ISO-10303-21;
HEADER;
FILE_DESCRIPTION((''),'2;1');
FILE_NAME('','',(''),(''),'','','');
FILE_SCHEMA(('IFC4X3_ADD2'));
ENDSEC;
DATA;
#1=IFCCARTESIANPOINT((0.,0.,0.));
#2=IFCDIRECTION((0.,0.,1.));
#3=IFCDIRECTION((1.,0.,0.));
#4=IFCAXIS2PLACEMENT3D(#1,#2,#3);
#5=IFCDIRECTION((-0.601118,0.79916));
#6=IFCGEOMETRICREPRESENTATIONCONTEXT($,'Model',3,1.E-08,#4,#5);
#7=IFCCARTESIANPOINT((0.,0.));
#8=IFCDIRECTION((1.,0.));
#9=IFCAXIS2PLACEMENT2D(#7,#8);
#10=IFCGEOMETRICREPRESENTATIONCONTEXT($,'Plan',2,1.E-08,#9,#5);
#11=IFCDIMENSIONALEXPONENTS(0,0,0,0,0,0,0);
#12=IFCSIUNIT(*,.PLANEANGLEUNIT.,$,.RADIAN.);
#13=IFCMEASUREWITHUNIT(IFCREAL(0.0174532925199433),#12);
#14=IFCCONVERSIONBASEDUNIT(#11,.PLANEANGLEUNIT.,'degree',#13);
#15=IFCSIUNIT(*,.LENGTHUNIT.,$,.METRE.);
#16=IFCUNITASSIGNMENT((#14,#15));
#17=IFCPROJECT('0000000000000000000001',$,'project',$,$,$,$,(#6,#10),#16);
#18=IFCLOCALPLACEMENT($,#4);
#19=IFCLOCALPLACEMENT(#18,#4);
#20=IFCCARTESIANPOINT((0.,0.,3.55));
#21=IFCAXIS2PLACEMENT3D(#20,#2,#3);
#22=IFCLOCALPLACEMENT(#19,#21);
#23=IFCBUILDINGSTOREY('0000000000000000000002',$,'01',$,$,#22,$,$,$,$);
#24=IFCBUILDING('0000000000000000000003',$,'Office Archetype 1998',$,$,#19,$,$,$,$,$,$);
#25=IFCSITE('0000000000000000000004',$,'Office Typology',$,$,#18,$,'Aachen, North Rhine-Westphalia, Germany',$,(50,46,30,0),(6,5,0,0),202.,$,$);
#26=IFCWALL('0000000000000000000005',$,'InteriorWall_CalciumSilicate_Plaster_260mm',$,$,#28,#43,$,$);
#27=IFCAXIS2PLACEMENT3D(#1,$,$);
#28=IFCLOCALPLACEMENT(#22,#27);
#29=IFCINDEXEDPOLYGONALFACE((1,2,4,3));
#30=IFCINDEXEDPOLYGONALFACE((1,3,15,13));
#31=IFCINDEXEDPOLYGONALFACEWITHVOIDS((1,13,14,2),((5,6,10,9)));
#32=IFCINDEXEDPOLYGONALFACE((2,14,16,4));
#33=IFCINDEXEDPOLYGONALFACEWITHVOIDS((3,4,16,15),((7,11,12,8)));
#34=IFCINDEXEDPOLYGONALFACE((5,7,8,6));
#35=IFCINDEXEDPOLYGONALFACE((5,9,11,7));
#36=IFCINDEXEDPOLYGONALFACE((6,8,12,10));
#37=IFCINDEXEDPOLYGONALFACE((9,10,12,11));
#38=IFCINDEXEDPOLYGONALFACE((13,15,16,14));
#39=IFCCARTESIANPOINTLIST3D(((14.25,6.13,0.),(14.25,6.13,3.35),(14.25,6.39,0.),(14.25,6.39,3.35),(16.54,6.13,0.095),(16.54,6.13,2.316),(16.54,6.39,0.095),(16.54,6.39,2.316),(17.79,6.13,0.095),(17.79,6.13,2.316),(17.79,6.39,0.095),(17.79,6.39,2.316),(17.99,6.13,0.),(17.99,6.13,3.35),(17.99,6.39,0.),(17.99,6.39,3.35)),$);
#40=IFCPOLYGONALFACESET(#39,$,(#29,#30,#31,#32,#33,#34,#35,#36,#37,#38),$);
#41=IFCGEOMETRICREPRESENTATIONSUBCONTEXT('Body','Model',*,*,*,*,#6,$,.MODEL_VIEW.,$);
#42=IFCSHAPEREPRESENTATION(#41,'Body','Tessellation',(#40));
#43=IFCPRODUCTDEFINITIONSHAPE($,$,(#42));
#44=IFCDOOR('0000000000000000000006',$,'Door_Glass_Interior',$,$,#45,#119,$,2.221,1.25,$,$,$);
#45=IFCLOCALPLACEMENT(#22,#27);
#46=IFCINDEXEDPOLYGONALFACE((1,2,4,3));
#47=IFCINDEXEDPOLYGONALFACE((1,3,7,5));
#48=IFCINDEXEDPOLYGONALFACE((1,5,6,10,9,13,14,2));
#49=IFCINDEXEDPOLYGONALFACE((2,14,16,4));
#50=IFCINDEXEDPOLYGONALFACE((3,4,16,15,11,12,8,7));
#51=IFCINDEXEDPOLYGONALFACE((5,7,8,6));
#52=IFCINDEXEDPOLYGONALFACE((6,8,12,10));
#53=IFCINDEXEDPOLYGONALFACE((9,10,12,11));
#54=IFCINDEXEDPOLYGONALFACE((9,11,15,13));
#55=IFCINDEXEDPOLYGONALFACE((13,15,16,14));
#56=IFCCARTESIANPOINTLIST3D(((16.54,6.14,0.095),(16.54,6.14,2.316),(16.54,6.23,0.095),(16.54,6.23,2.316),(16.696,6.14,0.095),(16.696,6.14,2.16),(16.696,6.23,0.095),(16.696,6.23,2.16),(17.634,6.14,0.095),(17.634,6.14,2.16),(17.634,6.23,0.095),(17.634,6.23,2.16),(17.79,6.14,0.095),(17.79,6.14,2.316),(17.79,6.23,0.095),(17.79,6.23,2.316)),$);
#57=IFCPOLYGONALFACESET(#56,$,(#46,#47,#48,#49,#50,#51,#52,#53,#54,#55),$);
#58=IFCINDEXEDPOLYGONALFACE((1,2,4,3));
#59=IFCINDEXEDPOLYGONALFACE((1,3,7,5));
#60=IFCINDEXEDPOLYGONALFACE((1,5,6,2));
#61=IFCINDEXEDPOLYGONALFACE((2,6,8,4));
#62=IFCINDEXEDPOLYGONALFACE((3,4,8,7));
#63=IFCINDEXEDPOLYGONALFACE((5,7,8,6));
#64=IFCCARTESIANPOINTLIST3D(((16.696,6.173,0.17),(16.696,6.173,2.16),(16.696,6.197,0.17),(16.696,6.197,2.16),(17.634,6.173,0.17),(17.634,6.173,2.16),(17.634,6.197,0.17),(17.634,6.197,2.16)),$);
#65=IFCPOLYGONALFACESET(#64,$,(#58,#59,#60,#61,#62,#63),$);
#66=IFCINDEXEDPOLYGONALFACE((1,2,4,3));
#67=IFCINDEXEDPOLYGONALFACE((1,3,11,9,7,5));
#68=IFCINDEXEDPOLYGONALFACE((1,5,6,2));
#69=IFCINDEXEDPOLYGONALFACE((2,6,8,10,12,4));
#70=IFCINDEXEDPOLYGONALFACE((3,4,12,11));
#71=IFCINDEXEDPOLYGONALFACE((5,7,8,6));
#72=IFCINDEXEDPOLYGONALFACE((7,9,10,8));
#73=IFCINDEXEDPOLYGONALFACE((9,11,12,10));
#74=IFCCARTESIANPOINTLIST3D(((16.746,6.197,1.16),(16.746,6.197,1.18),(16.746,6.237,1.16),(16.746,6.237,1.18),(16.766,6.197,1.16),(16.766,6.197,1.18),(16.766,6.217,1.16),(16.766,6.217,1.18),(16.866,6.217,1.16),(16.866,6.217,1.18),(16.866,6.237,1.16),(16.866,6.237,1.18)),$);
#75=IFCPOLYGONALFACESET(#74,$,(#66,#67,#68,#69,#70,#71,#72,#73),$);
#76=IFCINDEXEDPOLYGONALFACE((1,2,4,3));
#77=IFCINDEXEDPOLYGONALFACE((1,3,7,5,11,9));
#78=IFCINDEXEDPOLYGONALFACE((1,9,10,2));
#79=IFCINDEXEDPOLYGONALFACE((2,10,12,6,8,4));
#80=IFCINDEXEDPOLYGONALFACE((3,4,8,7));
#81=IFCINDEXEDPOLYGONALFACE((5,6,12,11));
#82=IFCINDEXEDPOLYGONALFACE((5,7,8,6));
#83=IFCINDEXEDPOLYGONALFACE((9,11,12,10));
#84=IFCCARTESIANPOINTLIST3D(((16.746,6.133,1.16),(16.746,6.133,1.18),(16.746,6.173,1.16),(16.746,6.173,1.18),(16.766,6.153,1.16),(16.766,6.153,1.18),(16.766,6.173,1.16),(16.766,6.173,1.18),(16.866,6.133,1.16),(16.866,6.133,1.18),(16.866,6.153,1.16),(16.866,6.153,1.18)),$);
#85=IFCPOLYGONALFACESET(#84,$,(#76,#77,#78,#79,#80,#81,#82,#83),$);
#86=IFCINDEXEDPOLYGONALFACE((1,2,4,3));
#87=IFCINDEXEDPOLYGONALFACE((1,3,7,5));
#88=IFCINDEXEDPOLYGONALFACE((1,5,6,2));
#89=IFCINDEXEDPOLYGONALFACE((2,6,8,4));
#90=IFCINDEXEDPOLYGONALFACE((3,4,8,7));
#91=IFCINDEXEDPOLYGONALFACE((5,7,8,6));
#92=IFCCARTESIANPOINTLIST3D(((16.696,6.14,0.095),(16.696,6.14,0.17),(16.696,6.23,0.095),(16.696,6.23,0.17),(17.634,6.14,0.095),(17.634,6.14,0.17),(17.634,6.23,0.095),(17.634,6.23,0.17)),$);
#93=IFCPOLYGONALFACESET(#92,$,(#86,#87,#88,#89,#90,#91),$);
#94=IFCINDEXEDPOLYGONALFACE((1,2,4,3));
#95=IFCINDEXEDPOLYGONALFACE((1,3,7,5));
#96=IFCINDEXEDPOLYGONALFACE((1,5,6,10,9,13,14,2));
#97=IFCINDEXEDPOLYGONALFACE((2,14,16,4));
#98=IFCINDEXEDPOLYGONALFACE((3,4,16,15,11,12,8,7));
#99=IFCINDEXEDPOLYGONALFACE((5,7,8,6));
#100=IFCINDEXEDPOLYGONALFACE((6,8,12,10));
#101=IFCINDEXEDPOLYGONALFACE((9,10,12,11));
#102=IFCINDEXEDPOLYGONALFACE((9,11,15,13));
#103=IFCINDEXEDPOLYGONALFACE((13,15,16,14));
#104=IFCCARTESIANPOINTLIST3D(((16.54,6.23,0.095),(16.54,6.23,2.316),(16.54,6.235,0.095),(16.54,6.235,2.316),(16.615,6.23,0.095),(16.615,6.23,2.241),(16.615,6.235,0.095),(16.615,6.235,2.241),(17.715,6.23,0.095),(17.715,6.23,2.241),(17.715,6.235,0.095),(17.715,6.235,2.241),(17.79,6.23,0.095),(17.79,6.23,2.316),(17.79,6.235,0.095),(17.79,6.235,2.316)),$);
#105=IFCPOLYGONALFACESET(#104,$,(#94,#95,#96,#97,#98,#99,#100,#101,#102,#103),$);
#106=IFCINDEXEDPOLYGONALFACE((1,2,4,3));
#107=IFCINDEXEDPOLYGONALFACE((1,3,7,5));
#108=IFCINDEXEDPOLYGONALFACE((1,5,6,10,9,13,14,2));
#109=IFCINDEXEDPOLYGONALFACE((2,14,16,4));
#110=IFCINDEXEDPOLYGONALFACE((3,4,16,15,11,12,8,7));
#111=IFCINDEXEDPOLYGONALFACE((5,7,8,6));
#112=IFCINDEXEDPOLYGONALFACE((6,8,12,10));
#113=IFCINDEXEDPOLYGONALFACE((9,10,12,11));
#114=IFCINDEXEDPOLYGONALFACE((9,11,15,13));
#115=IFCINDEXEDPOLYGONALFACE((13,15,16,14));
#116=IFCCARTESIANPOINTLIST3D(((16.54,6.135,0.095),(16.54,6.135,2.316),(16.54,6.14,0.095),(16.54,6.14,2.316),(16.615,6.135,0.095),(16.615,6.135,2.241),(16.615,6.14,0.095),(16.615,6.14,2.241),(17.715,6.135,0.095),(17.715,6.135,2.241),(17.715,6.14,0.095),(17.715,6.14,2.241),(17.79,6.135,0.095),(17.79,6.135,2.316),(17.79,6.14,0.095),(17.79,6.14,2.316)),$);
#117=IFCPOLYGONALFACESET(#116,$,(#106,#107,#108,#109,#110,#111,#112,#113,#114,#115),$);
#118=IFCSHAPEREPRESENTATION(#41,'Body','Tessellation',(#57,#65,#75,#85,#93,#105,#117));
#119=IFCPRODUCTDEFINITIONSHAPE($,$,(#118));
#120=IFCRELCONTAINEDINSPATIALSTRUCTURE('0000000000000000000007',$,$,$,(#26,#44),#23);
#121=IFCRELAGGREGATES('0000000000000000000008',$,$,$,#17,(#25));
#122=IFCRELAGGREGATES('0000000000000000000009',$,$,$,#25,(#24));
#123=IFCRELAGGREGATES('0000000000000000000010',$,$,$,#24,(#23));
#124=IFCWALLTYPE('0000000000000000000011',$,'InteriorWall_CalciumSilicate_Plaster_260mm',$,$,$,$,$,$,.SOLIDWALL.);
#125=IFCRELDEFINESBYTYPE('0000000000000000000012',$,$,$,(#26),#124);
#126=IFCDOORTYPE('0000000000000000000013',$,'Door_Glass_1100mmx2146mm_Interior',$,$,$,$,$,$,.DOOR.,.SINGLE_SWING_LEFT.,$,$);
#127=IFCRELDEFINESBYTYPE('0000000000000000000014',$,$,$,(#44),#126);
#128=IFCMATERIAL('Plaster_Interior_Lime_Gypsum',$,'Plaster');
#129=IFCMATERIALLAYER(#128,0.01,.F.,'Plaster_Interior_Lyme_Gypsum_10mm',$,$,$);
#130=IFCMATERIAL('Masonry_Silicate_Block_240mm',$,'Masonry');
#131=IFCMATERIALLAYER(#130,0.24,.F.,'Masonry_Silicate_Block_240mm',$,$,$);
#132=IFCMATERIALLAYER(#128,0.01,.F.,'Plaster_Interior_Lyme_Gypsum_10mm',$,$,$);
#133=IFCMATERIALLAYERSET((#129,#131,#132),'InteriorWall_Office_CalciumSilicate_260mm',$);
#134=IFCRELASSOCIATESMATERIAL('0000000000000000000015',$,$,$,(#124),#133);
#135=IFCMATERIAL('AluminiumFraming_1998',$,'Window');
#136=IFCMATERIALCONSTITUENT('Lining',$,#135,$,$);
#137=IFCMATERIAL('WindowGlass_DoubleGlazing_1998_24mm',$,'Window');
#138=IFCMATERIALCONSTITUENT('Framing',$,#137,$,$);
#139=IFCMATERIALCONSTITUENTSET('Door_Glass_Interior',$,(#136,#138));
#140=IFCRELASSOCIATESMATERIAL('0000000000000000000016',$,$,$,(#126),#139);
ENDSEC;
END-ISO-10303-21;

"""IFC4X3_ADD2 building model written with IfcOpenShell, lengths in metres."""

from ifc_helpers import new_model, entity, si_unit, converted_unit, direction, frame, origin_with_axes, origin_2d_with_axis, place, context, subcontext, project, spatial, line, indexed_curve, outline, extrude, source, transform, mapped, material, layer, layer_set, constituent, constituent_set, type_object, type_shapes, element, fill, save


model = new_model("IFC4X3_ADD2")

# Units and contexts
model_context = context("Model", 3, precision=1e-08, world=origin_with_axes(), true_north=direction((-0.601118, 0.79916)))
plan_context = context("Plan", 2, precision=1e-08, world=origin_2d_with_axis(), true_north=direction((-0.601118, 0.79916)))
body_context = subcontext(model_context, "Body", "Model", "MODEL_VIEW")
ifc_project = project(units=[converted_unit("PLANEANGLEUNIT", "degree", entity("IfcReal", 0.0174532925199433), si_unit("PLANEANGLEUNIT", "RADIAN"), dimensions=[0, 0, 0, 0, 0, 0, 0]), si_unit("LENGTHUNIT", "METRE")], contexts=[model_context, plan_context])

# Site, building, storey
site_placement = place(None, origin_with_axes())
site = spatial("IfcSite", under=ifc_project, at=site_placement, Name="Office Typology", LongName="Aachen, North Rhine-Westphalia, Germany", RefLatitude=(50, 46, 30, 0), RefLongitude=(6, 5, 0, 0), RefElevation=202.0)
building_placement = place(site_placement, origin_with_axes())
building = spatial("IfcBuilding", under=site, at=building_placement, Name="Office Archetype 1998")
storey_placement = place(building_placement, frame((0.0, 0.0, 3.55), z_axis=(0.0, 0.0, 1.0), x_axis=(1.0, 0.0, 0.0)))
storey = spatial("IfcBuildingStorey", under=building, at=storey_placement, Name="01")

# Shared definitions
ifc_material_1 = material(Name="Plaster_Interior_Lime_Gypsum", Category="Plaster")
ifc_layer_1 = layer(ifc_material_1, 0.01, ventilated=False, Name="Plaster_Interior_Lyme_Gypsum_10mm")
ifc_material_2 = material(Name="Masonry_Silicate_Block_240mm", Category="Masonry")
ifc_layer_2 = layer(ifc_material_2, 0.24, ventilated=False, Name="Masonry_Silicate_Block_240mm")
ifc_layer_3 = layer(ifc_material_1, 0.01, ventilated=False, Name="Plaster_Interior_Lyme_Gypsum_10mm")
ifc_layer_set = layer_set([ifc_layer_1, ifc_layer_2, ifc_layer_3], Name="InteriorWall_Office_CalciumSilicate_260mm")
wall_type = type_object("IfcWallType", Name="InteriorWall_CalciumSilicate_Plaster_260mm", PredefinedType="SOLIDWALL", material=ifc_layer_set)

# Wall, opening, door
wall_1_placement = place(storey_placement, frame((18.25, 6.39, 0.0), z_axis=(0.0, 0.0, 1.0), x_axis=(-1.0, 0.0, 0.0)))
wall_1 = element("IfcWall", 1, at=wall_1_placement, inside=storey, type_object=wall_type, Name="InteriorWall_CalciumSilicate_Plaster_260mm", context=body_context, shape_type="SweptSolid", body=[
    extrude(outline(indexed_curve([(0.26, 0.0), (0.26, 0.26), (4.0, 0.26), (4.0, 0.0)], segments=[line(1, 2, 3, 4, 1)])), origin_with_axes(), (0.0, 0.0, 1.0), 3.35),
])
shared_shape_1 = source(origin_with_axes(), body_context, "Body", "SweptSolid", [
    extrude(outline(indexed_curve([(0.0, 2.221), (1.25, 2.221), (1.25, 0.0), (0.0, 0.0), (0.0, 2.221)])), frame((0.0, -0.16, 0.0), z_axis=(0.0, -1.0, 0.0), x_axis=(1.0, 0.0, 0.0)), (0.0, 0.0, -1.0), 0.26),
])
opening_1_placement = place(wall_1_placement, frame((0.46, 0.16, 0.095), z_axis=(0.0, 0.0, 1.0), x_axis=(1.0, 0.0, 0.0)))
opening_1 = element("IfcOpeningElement", 2, at=opening_1_placement, cuts=wall_1, PredefinedType="OPENING", context=body_context, shape_type="MappedRepresentation", body=[
    mapped(shared_shape_1, transform((0.0, 0.0, 0.0), x_axis=(1.0, 0.0, 0.0), y_axis=(0.0, 1.0, 0.0), z_axis=(0.0, 0.0, 1.0), scale=1.0)),
])
ifc_material_3 = material(Name="AluminiumFraming_1998", Category="Window")
ifc_constituent_1 = constituent(ifc_material_3, Name="Lining")
ifc_material_4 = material(Name="WindowGlass_DoubleGlazing_1998_24mm", Category="Window")
ifc_constituent_2 = constituent(ifc_material_4, Name="Framing")
ifc_constituent_set_1 = constituent_set(constituents=[ifc_constituent_1, ifc_constituent_2], Name="Door_Glass_Interior")
door_type_1 = type_object("IfcDoorType", Name="Door_Glass_1100mmx2146mm_Interior", OperationType="SINGLE_SWING_LEFT", PredefinedType="DOOR", material=ifc_constituent_set_1)
shared_shape_2 = source(origin_with_axes(), body_context, "Body", "SweptSolid", [
    extrude(outline(indexed_curve([(0.0, 0.0), (0.0, 2.221), (1.25, 2.221), (1.25, 0.0), (1.094, 0.0), (1.094, 2.065), (0.156, 2.065), (0.156, 0.0)], segments=[line(1, 2, 3, 4, 5, 6, 7, 8, 1)])), frame((0.0, 0.0, 0.0), z_axis=(0.0, -1.0, 0.0), x_axis=(1.0, 0.0, 0.0)), (0.0, 0.0, -1.0), 0.09),
    extrude(outline(indexed_curve([(0.0, 0.0), (0.938, 0.0), (0.938, 0.024), (0.0, 0.024)], segments=[line(1, 2, 3, 4, 1)])), frame((0.156, 0.033, 0.075), z_axis=(0.0, 0.0, 1.0), x_axis=(1.0, 0.0, 0.0)), (0.0, 0.0, 1.0), 1.99),
    extrude(outline(indexed_curve([(0.0, 0.0), (0.0, -0.04), (-0.12, -0.04), (-0.12, -0.02), (-0.02, -0.02), (-0.02, 0.0)], segments=[line(1, 2, 3, 4, 5, 6, 1)])), frame((1.044, 0.033, 1.065), z_axis=(0.0, 0.0, 1.0), x_axis=(1.0, 0.0, 0.0)), (0.0, 0.0, 1.0), 0.02),
    extrude(outline(indexed_curve([(0.0, 0.0), (0.0, 0.04), (-0.12, 0.04), (-0.12, 0.02), (-0.02, 0.02), (-0.02, 0.0)], segments=[line(1, 2, 3, 4, 5, 6, 1)])), frame((1.044, 0.057, 1.065), z_axis=(0.0, 0.0, 1.0), x_axis=(1.0, 0.0, 0.0)), (0.0, 0.0, 1.0), 0.02),
    extrude(outline(indexed_curve([(0.0, 0.0), (0.938, 0.0), (0.938, 0.09), (0.0, 0.09)], segments=[line(1, 2, 3, 4, 1)])), frame((0.156, 0.0, 0.0), z_axis=(0.0, 0.0, 1.0), x_axis=(1.0, 0.0, 0.0)), (0.0, 0.0, 1.0), 0.075),
    extrude(outline(indexed_curve([(0.0, 0.0), (0.0, 2.221), (1.25, 2.221), (1.25, 0.0), (1.175, 0.0), (1.175, 2.146), (0.075, 2.146), (0.075, 0.0)], segments=[line(1, 2, 3, 4, 5, 6, 7, 8, 1)])), frame((0.0, -0.005, 0.0), z_axis=(0.0, -1.0, 0.0), x_axis=(1.0, 0.0, 0.0)), (0.0, 0.0, -1.0), 0.005),
    extrude(outline(indexed_curve([(0.0, 0.0), (0.0, 2.221), (1.25, 2.221), (1.25, 0.0), (1.175, 0.0), (1.175, 2.146), (0.075, 2.146), (0.075, 0.0)], segments=[line(1, 2, 3, 4, 5, 6, 7, 8, 1)])), frame((0.0, 0.09, 0.0), z_axis=(0.0, -1.0, 0.0), x_axis=(1.0, 0.0, 0.0)), (0.0, 0.0, -1.0), 0.005),
])
type_shapes(door_type_1, [shared_shape_2])
door_1_placement = place(opening_1_placement, origin_with_axes())
door_1 = element("IfcDoor", 3, at=door_1_placement, inside=storey, type_object=door_type_1, Name="Door_Glass_Interior", OverallHeight=2.221, OverallWidth=1.25, context=body_context, shape_type="MappedRepresentation", body=[
    mapped(shared_shape_2, transform((0.0, 0.0, 0.0), x_axis=(1.0, 0.0, 0.0), y_axis=(0.0, 1.0, 0.0), z_axis=(0.0, 0.0, 1.0), scale=1.0)),
])
fill(opening_1, door_1)

save(model, "model.ifc")
